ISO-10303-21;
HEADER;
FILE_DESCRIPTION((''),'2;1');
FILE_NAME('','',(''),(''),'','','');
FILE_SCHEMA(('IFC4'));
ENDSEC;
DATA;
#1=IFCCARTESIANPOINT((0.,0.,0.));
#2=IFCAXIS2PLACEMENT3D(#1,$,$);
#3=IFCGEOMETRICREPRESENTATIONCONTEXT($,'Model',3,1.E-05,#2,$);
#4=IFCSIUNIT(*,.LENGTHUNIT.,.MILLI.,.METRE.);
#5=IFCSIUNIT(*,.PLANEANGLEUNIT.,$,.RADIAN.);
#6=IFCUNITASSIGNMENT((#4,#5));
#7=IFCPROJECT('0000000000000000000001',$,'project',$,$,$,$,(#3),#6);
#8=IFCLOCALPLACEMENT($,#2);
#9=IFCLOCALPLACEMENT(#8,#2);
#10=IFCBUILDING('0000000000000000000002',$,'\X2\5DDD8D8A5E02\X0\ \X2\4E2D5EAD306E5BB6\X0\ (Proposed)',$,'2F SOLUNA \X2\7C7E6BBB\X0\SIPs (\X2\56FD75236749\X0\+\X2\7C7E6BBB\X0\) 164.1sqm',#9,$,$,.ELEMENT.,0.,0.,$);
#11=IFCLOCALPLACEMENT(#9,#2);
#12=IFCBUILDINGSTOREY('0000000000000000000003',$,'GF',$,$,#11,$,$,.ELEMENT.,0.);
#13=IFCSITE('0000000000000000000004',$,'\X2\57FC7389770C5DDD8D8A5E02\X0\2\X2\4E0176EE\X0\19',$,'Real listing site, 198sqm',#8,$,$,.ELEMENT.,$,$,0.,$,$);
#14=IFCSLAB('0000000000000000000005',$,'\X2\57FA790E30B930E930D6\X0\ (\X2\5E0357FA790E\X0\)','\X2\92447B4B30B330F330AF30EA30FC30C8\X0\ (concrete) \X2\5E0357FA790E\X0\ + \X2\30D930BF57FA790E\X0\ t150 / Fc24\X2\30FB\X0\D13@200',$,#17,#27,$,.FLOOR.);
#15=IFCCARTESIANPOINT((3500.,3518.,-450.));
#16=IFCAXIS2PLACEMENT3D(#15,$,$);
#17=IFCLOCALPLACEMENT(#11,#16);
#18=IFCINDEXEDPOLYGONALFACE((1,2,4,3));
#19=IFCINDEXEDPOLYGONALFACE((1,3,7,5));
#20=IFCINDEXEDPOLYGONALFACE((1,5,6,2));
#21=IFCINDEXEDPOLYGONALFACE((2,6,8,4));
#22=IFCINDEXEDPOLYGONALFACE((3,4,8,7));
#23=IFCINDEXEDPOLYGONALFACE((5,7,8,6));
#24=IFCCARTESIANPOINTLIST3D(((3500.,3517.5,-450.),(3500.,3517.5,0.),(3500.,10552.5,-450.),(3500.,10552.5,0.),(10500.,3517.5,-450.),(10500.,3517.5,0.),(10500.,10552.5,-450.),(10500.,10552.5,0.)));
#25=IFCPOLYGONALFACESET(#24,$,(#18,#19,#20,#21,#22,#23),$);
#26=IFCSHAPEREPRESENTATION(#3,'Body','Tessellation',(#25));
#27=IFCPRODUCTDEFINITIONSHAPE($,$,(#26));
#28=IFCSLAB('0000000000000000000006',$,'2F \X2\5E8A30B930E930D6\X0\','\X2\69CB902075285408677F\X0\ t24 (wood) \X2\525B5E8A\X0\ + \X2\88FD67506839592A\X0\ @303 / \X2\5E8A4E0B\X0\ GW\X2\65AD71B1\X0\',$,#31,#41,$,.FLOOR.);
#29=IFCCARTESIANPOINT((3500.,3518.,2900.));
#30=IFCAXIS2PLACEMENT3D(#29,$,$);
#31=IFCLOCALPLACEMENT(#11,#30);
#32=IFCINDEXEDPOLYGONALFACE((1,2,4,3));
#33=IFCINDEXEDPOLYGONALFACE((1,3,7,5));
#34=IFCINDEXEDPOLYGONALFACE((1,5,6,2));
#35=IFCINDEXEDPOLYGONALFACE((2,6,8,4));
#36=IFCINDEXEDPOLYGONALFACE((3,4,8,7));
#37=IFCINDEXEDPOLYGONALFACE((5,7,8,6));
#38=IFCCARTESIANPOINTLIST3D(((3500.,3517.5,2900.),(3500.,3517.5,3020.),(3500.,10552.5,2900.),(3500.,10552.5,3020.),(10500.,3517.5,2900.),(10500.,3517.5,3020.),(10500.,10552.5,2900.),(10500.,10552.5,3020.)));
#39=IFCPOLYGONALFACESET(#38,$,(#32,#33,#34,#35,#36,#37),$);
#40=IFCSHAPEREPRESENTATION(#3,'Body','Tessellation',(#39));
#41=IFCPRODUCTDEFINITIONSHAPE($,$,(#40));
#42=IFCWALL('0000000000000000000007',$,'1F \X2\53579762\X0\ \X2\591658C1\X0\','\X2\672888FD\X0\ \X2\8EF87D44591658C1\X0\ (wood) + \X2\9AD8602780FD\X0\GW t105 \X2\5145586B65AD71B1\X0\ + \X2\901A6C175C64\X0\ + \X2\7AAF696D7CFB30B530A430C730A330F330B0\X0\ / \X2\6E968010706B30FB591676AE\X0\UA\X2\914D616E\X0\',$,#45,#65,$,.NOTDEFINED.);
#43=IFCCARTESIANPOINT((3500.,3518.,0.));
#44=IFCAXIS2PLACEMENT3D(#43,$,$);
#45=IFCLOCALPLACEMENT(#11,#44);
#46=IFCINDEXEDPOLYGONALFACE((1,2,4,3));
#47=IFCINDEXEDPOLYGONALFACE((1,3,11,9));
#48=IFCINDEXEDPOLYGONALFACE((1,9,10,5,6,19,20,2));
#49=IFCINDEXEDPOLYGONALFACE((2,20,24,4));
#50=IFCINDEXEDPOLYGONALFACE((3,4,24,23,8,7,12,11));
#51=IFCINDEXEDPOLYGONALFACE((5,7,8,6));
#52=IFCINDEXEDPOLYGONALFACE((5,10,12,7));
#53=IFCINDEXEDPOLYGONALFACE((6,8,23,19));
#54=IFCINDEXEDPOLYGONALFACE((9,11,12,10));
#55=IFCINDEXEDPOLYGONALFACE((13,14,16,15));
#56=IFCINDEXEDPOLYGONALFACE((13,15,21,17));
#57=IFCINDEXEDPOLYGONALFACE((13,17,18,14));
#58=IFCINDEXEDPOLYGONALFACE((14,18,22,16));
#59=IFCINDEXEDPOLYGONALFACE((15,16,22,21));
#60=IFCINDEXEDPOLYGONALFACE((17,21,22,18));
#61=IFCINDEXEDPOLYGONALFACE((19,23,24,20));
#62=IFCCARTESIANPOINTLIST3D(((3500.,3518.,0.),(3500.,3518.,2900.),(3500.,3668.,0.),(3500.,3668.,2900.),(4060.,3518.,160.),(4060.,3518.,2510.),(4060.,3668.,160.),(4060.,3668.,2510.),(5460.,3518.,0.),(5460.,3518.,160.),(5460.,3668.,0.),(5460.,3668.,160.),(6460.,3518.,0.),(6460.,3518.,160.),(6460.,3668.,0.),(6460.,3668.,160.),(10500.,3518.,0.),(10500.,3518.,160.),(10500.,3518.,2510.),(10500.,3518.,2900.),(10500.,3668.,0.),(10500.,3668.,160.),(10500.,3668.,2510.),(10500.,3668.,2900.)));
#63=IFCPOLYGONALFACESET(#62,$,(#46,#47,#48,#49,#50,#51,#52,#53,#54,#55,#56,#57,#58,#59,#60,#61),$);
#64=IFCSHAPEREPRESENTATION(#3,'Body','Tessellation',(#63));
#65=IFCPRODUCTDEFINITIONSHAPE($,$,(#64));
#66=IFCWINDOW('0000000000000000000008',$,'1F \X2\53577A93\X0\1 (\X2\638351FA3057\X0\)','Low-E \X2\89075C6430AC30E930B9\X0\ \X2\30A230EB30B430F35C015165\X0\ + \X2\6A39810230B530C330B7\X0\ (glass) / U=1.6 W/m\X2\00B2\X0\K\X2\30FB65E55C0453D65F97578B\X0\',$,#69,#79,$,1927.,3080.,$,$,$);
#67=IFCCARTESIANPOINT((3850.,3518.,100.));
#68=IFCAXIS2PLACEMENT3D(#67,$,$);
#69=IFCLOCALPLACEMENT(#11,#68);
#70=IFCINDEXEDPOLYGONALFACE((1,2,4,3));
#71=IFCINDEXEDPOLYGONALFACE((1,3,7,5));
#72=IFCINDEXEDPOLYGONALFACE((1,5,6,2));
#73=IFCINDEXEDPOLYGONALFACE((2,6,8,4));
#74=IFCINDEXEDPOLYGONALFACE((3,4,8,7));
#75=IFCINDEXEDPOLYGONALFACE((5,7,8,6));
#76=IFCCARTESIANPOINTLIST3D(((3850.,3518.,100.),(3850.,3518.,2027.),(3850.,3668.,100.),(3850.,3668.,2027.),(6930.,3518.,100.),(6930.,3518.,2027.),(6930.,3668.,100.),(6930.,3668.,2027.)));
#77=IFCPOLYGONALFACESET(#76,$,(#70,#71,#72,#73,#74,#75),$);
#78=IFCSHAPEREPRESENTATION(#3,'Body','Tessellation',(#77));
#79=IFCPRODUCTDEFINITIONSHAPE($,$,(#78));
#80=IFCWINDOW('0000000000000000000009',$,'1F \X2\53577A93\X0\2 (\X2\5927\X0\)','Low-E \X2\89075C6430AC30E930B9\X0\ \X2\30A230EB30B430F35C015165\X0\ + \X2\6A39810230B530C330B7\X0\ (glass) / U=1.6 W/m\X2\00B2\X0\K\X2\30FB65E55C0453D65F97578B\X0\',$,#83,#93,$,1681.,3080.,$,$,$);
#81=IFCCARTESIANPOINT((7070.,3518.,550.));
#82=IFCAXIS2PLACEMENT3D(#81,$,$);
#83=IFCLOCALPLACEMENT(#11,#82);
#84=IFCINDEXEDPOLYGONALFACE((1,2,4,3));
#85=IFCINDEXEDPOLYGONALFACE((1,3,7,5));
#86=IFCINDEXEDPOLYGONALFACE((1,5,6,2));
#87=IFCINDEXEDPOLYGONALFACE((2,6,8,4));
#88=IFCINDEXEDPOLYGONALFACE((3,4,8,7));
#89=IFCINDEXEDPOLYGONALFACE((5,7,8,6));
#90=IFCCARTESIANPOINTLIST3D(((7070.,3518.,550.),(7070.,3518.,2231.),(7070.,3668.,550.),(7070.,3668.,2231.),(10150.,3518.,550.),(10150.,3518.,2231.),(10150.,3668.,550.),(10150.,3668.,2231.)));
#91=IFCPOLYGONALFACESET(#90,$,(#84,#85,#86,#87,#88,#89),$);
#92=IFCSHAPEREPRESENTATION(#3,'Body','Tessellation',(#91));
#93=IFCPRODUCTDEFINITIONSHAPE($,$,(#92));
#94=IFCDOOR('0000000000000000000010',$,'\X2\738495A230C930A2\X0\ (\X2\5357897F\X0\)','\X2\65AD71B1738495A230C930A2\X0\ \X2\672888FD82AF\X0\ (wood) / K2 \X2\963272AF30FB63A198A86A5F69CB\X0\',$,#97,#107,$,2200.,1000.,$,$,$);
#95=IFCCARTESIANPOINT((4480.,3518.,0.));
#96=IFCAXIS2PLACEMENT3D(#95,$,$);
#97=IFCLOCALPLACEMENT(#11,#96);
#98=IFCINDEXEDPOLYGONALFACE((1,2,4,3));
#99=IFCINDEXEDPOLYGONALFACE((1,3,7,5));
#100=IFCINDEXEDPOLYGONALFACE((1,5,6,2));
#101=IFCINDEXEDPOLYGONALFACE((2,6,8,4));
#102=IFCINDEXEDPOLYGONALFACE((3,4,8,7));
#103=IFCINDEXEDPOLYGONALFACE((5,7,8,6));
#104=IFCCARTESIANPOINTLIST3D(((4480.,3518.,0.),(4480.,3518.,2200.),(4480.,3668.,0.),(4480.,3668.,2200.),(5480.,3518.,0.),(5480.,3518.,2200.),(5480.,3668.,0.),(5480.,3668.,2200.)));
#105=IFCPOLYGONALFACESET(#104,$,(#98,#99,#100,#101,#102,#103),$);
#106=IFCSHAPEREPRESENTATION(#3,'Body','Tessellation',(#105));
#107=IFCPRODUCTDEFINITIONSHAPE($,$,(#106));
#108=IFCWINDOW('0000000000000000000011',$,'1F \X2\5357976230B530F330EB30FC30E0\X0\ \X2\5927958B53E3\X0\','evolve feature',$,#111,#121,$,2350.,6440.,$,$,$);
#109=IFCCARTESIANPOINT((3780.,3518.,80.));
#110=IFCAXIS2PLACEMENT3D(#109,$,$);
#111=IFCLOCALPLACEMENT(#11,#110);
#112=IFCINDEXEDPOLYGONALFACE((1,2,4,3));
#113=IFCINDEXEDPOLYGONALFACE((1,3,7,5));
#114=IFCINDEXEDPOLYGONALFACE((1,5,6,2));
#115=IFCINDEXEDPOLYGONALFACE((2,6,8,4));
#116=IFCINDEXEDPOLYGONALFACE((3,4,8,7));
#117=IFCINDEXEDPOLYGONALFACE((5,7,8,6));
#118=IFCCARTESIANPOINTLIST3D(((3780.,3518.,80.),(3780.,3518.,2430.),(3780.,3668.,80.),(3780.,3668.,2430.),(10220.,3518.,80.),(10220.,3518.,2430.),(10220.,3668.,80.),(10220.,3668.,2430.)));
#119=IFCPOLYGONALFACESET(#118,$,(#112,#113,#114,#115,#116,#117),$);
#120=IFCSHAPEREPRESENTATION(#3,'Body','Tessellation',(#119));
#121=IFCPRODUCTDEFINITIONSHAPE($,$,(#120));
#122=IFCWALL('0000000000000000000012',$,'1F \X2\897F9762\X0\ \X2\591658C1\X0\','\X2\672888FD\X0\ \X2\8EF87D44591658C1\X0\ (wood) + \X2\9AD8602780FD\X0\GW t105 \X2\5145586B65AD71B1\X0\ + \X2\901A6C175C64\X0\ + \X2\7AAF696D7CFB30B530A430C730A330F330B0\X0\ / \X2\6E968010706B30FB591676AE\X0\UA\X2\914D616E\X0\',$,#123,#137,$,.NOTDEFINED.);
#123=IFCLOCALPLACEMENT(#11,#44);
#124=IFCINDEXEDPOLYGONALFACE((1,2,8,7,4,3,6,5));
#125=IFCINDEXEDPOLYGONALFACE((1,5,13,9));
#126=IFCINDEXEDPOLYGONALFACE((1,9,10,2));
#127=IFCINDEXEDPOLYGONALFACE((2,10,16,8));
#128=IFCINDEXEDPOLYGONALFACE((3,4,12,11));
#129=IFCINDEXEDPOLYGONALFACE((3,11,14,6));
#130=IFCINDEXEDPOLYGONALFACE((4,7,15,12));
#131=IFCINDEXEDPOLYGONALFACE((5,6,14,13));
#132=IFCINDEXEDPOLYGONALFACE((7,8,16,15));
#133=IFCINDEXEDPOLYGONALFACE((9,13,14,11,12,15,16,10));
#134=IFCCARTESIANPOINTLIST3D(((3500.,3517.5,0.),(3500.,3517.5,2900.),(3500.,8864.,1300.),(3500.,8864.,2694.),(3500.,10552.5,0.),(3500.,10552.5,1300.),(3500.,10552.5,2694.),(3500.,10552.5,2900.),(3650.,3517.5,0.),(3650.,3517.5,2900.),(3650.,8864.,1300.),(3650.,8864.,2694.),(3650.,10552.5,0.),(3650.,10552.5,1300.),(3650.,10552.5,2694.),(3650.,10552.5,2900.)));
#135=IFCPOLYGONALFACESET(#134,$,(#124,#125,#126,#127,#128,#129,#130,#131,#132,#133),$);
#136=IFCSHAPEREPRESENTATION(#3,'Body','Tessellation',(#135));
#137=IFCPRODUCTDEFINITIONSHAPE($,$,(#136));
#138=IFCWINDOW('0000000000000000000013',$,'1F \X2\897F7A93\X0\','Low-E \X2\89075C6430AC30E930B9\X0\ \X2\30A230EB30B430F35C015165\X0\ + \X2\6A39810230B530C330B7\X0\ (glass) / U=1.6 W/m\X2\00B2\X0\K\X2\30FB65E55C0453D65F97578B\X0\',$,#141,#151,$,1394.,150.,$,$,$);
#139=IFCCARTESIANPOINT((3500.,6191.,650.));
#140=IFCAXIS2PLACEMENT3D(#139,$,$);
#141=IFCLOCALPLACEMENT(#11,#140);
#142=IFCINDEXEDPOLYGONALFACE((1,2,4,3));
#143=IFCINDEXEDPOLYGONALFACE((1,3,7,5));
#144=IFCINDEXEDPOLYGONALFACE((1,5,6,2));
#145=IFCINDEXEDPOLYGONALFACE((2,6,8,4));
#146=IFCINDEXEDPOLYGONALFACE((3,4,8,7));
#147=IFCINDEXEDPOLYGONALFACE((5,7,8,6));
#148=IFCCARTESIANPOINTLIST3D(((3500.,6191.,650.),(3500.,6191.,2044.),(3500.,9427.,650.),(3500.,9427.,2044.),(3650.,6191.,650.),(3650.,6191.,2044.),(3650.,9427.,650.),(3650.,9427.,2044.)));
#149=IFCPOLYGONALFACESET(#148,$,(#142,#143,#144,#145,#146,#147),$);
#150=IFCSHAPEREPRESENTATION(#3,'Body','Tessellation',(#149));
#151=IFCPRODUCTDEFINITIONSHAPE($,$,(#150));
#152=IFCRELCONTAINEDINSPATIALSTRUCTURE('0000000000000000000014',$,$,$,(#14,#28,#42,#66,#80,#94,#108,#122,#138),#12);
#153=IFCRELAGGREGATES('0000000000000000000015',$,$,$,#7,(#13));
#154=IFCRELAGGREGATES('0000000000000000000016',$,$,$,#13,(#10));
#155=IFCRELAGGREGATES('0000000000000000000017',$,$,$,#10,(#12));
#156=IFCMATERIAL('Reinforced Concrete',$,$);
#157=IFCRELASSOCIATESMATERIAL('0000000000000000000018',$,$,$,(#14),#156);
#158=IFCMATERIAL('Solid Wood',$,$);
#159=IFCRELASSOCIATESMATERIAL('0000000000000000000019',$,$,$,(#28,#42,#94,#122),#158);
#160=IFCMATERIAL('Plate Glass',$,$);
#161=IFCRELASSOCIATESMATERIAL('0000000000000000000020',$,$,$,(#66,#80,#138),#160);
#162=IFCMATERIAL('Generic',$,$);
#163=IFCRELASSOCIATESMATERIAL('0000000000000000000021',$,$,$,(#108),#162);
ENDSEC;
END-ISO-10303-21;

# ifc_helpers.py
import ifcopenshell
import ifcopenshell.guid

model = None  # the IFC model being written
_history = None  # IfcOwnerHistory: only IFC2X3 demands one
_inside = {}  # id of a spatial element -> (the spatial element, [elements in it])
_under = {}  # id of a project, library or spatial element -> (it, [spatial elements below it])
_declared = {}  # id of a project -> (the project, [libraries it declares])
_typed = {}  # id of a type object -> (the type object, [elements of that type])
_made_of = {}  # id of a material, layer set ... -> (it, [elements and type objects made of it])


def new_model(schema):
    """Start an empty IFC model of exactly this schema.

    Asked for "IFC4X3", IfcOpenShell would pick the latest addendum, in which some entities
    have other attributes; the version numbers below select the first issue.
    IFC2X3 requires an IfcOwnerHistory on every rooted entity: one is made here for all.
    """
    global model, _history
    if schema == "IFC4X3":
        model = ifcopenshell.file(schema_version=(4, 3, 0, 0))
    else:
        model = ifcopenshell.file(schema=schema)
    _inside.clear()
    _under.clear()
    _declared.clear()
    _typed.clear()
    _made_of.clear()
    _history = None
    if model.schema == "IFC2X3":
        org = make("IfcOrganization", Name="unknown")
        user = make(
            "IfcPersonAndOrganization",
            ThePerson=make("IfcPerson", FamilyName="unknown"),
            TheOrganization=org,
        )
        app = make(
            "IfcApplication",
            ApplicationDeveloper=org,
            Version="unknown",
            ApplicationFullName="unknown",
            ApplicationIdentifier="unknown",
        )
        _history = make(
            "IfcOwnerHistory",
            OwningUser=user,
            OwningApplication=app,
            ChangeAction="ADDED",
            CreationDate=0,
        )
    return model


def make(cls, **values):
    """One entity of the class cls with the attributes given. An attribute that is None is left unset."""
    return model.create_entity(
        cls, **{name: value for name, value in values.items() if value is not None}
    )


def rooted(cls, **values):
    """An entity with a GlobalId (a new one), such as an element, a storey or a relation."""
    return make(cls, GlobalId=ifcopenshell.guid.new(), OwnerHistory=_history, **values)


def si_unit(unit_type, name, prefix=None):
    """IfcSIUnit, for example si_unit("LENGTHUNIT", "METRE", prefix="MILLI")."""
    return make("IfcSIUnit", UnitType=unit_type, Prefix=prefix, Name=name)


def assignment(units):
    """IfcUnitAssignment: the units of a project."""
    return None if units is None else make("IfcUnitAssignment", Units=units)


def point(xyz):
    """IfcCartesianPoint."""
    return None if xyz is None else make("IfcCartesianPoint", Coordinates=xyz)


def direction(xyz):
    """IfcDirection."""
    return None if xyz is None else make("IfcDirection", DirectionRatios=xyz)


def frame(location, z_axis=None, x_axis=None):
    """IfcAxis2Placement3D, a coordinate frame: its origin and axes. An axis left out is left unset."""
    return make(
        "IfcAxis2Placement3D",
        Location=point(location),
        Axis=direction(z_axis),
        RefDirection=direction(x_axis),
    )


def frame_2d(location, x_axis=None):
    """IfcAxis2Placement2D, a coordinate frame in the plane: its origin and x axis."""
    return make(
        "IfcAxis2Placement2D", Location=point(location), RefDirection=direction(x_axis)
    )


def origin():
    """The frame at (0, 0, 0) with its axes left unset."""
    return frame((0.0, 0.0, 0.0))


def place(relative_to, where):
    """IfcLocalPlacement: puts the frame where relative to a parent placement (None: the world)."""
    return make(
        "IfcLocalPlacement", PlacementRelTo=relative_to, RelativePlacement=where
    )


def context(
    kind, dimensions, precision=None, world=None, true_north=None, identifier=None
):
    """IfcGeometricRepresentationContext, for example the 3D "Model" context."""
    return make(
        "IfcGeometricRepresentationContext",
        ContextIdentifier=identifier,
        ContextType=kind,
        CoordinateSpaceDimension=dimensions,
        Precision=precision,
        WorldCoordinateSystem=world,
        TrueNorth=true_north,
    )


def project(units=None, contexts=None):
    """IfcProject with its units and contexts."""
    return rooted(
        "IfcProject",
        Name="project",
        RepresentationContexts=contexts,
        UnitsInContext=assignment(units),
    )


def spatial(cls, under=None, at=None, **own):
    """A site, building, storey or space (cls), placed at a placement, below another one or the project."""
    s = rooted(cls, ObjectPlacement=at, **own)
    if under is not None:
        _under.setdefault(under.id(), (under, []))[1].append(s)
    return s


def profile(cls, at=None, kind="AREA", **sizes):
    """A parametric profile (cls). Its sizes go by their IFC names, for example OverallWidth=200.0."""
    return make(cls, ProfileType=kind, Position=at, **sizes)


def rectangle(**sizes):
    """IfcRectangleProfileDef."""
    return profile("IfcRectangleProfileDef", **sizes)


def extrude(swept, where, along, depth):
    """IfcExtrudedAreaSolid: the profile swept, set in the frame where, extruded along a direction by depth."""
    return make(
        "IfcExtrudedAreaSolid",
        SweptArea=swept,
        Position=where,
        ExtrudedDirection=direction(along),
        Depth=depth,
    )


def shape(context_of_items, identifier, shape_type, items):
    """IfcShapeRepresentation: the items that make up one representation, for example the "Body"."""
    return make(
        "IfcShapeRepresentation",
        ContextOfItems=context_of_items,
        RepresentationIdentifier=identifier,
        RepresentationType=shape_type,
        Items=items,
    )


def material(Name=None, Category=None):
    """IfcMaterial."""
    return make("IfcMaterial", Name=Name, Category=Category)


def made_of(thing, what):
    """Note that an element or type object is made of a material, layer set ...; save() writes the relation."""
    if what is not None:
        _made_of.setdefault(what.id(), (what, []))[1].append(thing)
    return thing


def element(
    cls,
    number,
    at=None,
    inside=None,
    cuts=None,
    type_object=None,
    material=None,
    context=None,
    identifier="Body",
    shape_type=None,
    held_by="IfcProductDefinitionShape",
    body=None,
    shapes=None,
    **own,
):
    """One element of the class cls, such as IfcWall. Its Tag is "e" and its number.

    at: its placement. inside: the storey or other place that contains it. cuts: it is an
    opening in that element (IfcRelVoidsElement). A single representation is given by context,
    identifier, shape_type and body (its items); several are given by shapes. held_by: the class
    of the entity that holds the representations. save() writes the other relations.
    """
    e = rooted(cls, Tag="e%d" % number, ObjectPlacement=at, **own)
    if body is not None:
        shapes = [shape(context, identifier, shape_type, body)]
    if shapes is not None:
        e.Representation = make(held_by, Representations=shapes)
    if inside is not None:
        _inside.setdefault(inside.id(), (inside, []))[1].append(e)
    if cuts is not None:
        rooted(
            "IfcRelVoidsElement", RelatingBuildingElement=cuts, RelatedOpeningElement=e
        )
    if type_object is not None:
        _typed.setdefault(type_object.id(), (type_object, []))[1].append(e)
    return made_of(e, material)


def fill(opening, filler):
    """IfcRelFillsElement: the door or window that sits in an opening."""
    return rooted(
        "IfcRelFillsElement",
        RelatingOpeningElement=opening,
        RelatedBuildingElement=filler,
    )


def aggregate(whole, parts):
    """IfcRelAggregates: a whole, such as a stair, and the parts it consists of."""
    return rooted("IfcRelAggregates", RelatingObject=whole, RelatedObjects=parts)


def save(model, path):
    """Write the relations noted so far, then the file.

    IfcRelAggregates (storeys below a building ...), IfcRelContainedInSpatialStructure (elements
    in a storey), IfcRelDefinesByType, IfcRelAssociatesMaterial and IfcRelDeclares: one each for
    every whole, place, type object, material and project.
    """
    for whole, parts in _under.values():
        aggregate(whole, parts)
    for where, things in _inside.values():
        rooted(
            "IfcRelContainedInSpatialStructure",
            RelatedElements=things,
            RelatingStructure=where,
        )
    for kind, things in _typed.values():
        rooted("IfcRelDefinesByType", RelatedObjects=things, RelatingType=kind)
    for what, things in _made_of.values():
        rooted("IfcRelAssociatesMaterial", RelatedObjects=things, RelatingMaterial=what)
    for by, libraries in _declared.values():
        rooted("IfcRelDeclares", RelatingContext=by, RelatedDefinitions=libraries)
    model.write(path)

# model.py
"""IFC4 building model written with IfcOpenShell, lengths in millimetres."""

from ifc_helpers import new_model, si_unit, frame, frame_2d, origin, place, context, project, spatial, rectangle, extrude, material, element, fill, save


model = new_model("IFC4")

# Units and contexts
model_context = context("Model", 3, precision=1e-05, world=origin())
ifc_project = project(units=[si_unit("LENGTHUNIT", "METRE", prefix="MILLI"), si_unit("PLANEANGLEUNIT", "RADIAN")], contexts=[model_context])

# Site, building, storey
site_placement = place(None, origin())
site = spatial("IfcSite", under=ifc_project, at=site_placement, Name="埼玉県川越市2丁目19", ObjectType="Real listing site, 198sqm", CompositionType="ELEMENT", RefElevation=0.0)
building_placement = place(site_placement, origin())
building = spatial("IfcBuilding", under=site, at=building_placement, Name="川越市 中庭の家 (Proposed)", ObjectType="2F SOLUNA 籾殻SIPs (国産杉+籾殻) 164.1sqm", CompositionType="ELEMENT", ElevationOfRefHeight=0.0, ElevationOfTerrain=0.0)
storey_placement = place(building_placement, origin())
storey = spatial("IfcBuildingStorey", under=building, at=storey_placement, Name="GF", CompositionType="ELEMENT", Elevation=0.0)

# Slabs
ifc_material_1 = material(Name="Reinforced Concrete")
slab_1_placement = place(storey_placement, frame((3500.0, 3518.0, -450.0)))
element("IfcSlab", 1, at=slab_1_placement, inside=storey, material=ifc_material_1, Name="基礎スラブ (布基礎)", Description="鉄筋コンクリート (concrete) 布基礎 + ベタ基礎 t150 / Fc24・D13@200", PredefinedType="FLOOR", context=model_context, shape_type="SweptSolid", body=[
    extrude(rectangle(XDim=7000.0, YDim=7035.0, at=frame_2d((3500.0, 3517.0))), frame((3500.0, 3518.0, -450.0)), (0.0, 0.0, 1.0), 450.0),
])
ifc_material_2 = material(Name="Solid Wood")
slab_2_placement = place(storey_placement, frame((3500.0, 3518.0, 2900.0)))
element("IfcSlab", 2, at=slab_2_placement, inside=storey, material=ifc_material_2, Name="2F 床スラブ", Description="構造用合板 t24 (wood) 剛床 + 製材根太 @303 / 床下 GW断熱", PredefinedType="FLOOR", context=model_context, shape_type="SweptSolid", body=[
    extrude(rectangle(XDim=7000.0, YDim=7035.0, at=frame_2d((3500.0, 3517.0))), frame((3500.0, 3518.0, 2900.0)), (0.0, 0.0, 1.0), 120.0),
])
ifc_material_3 = material(Name="Generic")

# Wall, openings, windows, door
wall_1_placement = place(storey_placement, frame((3500.0, 3518.0, 0.0)))
wall_1 = element("IfcWall", 3, at=wall_1_placement, inside=storey, material=ifc_material_2, Name="1F 南面 外壁", Description="木製 軸組外壁 (wood) + 高性能GW t105 充填断熱 + 通気層 + 窯業系サイディング / 準耐火・外皮UA配慮", PredefinedType="NOTDEFINED", context=model_context, shape_type="SweptSolid", body=[
    extrude(rectangle(XDim=7000.0, YDim=150.0, at=frame_2d((3500.0, 75.0))), frame((3500.0, 3518.0, 0.0)), (0.0, 0.0, 1.0), 2900.0),
])
opening_1_placement = place(storey_placement, frame((3850.0, 3518.0, 100.0)))
opening_1 = element("IfcOpeningElement", 4, at=opening_1_placement, cuts=wall_1, PredefinedType="NOTDEFINED", context=model_context, shape_type="SweptSolid", body=[
    extrude(rectangle(XDim=3080.0, YDim=150.0, at=frame_2d((1540.0, 75.0))), frame((3850.0, 3518.0, 100.0)), (0.0, 0.0, 1.0), 1927.0),
])
opening_2_placement = place(storey_placement, frame((7070.0, 3518.0, 550.0)))
opening_2 = element("IfcOpeningElement", 5, at=opening_2_placement, cuts=wall_1, PredefinedType="NOTDEFINED", context=model_context, shape_type="SweptSolid", body=[
    extrude(rectangle(XDim=3080.0, YDim=150.0, at=frame_2d((1540.0, 75.0))), frame((7070.0, 3518.0, 550.0)), (0.0, 0.0, 1.0), 1681.0),
])
opening_3_placement = place(storey_placement, frame((4480.0, 3518.0, 0.0)))
opening_3 = element("IfcOpeningElement", 6, at=opening_3_placement, cuts=wall_1, PredefinedType="NOTDEFINED", context=model_context, shape_type="SweptSolid", body=[
    extrude(rectangle(XDim=1000.0, YDim=150.0, at=frame_2d((500.0, 75.0))), frame((4480.0, 3518.0, 0.0)), (0.0, 0.0, 1.0), 2200.0),
])
opening_4_placement = place(storey_placement, frame((3780.0, 3518.0, 80.0)))
opening_4 = element("IfcOpeningElement", 7, at=opening_4_placement, cuts=wall_1, PredefinedType="NOTDEFINED", context=model_context, shape_type="SweptSolid", body=[
    extrude(rectangle(XDim=6440.0, YDim=150.0, at=frame_2d((3220.0, 75.0))), frame((3780.0, 3518.0, 80.0)), (0.0, 0.0, 1.0), 2350.0),
])
ifc_material_4 = material(Name="Plate Glass")
window_1_placement = place(storey_placement, frame((3850.0, 3518.0, 100.0)))
window_1 = element("IfcWindow", 8, at=window_1_placement, inside=storey, material=ifc_material_4, Name="1F 南窓1 (掃出し)", Description="Low-E 複層ガラス アルゴン封入 + 樹脂サッシ (glass) / U=1.6 W/m²K・日射取得型", OverallHeight=1927.0, OverallWidth=3080.0, context=model_context, shape_type="SweptSolid", body=[
    extrude(rectangle(XDim=3080.0, YDim=150.0, at=frame_2d((1540.0, 75.0))), frame((3850.0, 3518.0, 100.0)), (0.0, 0.0, 1.0), 1927.0),
])
fill(opening_1, window_1)
window_2_placement = place(storey_placement, frame((7070.0, 3518.0, 550.0)))
window_2 = element("IfcWindow", 9, at=window_2_placement, inside=storey, material=ifc_material_4, Name="1F 南窓2 (大)", Description="Low-E 複層ガラス アルゴン封入 + 樹脂サッシ (glass) / U=1.6 W/m²K・日射取得型", OverallHeight=1681.0, OverallWidth=3080.0, context=model_context, shape_type="SweptSolid", body=[
    extrude(rectangle(XDim=3080.0, YDim=150.0, at=frame_2d((1540.0, 75.0))), frame((7070.0, 3518.0, 550.0)), (0.0, 0.0, 1.0), 1681.0),
])
fill(opening_2, window_2)
door_placement = place(storey_placement, frame((4480.0, 3518.0, 0.0)))
door = element("IfcDoor", 10, at=door_placement, inside=storey, material=ifc_material_2, Name="玄関ドア (南西)", Description="断熱玄関ドア 木製芯 (wood) / K2 防犯・採風機構", OverallHeight=2200.0, OverallWidth=1000.0, context=model_context, shape_type="SweptSolid", body=[
    extrude(rectangle(XDim=1000.0, YDim=150.0, at=frame_2d((500.0, 75.0))), frame((4480.0, 3518.0, 0.0)), (0.0, 0.0, 1.0), 2200.0),
])
fill(opening_3, door)
window_3_placement = place(storey_placement, frame((3780.0, 3518.0, 80.0)))
window_3 = element("IfcWindow", 11, at=window_3_placement, inside=storey, material=ifc_material_3, Name="1F 南面サンルーム 大開口", Description="evolve feature", OverallHeight=2350.0, OverallWidth=6440.0, context=model_context, shape_type="SweptSolid", body=[
    extrude(rectangle(XDim=6440.0, YDim=150.0, at=frame_2d((3220.0, 75.0))), frame((3780.0, 3518.0, 80.0)), (0.0, 0.0, 1.0), 2350.0),
])
fill(opening_4, window_3)

# Wall, opening, window
wall_2_placement = place(storey_placement, frame((3500.0, 3518.0, 0.0)))
wall_2 = element("IfcWall", 12, at=wall_2_placement, inside=storey, material=ifc_material_2, Name="1F 西面 外壁", Description="木製 軸組外壁 (wood) + 高性能GW t105 充填断熱 + 通気層 + 窯業系サイディング / 準耐火・外皮UA配慮", PredefinedType="NOTDEFINED", context=model_context, shape_type="SweptSolid", body=[
    extrude(rectangle(XDim=150.0, YDim=7035.0, at=frame_2d((75.0, 3517.0))), frame((3500.0, 3518.0, 0.0)), (0.0, 0.0, 1.0), 2900.0),
])
opening_5_placement = place(storey_placement, frame((3500.0, 6191.0, 650.0)))
opening_5 = element("IfcOpeningElement", 13, at=opening_5_placement, cuts=wall_2, PredefinedType="NOTDEFINED", context=model_context, shape_type="SweptSolid", body=[
    extrude(rectangle(XDim=150.0, YDim=3236.0, at=frame_2d((75.0, 1618.0))), frame((3500.0, 6191.0, 650.0)), (0.0, 0.0, 1.0), 1394.0),
])
window_4_placement = place(storey_placement, frame((3500.0, 6191.0, 650.0)))
window_4 = element("IfcWindow", 14, at=window_4_placement, inside=storey, material=ifc_material_4, Name="1F 西窓", Description="Low-E 複層ガラス アルゴン封入 + 樹脂サッシ (glass) / U=1.6 W/m²K・日射取得型", OverallHeight=1394.0, OverallWidth=150.0, context=model_context, shape_type="SweptSolid", body=[
    extrude(rectangle(XDim=150.0, YDim=3236.0, at=frame_2d((75.0, 1618.0))), frame((3500.0, 6191.0, 650.0)), (0.0, 0.0, 1.0), 1394.0),
])
fill(opening_5, window_4)

save(model, "model.ifc")
